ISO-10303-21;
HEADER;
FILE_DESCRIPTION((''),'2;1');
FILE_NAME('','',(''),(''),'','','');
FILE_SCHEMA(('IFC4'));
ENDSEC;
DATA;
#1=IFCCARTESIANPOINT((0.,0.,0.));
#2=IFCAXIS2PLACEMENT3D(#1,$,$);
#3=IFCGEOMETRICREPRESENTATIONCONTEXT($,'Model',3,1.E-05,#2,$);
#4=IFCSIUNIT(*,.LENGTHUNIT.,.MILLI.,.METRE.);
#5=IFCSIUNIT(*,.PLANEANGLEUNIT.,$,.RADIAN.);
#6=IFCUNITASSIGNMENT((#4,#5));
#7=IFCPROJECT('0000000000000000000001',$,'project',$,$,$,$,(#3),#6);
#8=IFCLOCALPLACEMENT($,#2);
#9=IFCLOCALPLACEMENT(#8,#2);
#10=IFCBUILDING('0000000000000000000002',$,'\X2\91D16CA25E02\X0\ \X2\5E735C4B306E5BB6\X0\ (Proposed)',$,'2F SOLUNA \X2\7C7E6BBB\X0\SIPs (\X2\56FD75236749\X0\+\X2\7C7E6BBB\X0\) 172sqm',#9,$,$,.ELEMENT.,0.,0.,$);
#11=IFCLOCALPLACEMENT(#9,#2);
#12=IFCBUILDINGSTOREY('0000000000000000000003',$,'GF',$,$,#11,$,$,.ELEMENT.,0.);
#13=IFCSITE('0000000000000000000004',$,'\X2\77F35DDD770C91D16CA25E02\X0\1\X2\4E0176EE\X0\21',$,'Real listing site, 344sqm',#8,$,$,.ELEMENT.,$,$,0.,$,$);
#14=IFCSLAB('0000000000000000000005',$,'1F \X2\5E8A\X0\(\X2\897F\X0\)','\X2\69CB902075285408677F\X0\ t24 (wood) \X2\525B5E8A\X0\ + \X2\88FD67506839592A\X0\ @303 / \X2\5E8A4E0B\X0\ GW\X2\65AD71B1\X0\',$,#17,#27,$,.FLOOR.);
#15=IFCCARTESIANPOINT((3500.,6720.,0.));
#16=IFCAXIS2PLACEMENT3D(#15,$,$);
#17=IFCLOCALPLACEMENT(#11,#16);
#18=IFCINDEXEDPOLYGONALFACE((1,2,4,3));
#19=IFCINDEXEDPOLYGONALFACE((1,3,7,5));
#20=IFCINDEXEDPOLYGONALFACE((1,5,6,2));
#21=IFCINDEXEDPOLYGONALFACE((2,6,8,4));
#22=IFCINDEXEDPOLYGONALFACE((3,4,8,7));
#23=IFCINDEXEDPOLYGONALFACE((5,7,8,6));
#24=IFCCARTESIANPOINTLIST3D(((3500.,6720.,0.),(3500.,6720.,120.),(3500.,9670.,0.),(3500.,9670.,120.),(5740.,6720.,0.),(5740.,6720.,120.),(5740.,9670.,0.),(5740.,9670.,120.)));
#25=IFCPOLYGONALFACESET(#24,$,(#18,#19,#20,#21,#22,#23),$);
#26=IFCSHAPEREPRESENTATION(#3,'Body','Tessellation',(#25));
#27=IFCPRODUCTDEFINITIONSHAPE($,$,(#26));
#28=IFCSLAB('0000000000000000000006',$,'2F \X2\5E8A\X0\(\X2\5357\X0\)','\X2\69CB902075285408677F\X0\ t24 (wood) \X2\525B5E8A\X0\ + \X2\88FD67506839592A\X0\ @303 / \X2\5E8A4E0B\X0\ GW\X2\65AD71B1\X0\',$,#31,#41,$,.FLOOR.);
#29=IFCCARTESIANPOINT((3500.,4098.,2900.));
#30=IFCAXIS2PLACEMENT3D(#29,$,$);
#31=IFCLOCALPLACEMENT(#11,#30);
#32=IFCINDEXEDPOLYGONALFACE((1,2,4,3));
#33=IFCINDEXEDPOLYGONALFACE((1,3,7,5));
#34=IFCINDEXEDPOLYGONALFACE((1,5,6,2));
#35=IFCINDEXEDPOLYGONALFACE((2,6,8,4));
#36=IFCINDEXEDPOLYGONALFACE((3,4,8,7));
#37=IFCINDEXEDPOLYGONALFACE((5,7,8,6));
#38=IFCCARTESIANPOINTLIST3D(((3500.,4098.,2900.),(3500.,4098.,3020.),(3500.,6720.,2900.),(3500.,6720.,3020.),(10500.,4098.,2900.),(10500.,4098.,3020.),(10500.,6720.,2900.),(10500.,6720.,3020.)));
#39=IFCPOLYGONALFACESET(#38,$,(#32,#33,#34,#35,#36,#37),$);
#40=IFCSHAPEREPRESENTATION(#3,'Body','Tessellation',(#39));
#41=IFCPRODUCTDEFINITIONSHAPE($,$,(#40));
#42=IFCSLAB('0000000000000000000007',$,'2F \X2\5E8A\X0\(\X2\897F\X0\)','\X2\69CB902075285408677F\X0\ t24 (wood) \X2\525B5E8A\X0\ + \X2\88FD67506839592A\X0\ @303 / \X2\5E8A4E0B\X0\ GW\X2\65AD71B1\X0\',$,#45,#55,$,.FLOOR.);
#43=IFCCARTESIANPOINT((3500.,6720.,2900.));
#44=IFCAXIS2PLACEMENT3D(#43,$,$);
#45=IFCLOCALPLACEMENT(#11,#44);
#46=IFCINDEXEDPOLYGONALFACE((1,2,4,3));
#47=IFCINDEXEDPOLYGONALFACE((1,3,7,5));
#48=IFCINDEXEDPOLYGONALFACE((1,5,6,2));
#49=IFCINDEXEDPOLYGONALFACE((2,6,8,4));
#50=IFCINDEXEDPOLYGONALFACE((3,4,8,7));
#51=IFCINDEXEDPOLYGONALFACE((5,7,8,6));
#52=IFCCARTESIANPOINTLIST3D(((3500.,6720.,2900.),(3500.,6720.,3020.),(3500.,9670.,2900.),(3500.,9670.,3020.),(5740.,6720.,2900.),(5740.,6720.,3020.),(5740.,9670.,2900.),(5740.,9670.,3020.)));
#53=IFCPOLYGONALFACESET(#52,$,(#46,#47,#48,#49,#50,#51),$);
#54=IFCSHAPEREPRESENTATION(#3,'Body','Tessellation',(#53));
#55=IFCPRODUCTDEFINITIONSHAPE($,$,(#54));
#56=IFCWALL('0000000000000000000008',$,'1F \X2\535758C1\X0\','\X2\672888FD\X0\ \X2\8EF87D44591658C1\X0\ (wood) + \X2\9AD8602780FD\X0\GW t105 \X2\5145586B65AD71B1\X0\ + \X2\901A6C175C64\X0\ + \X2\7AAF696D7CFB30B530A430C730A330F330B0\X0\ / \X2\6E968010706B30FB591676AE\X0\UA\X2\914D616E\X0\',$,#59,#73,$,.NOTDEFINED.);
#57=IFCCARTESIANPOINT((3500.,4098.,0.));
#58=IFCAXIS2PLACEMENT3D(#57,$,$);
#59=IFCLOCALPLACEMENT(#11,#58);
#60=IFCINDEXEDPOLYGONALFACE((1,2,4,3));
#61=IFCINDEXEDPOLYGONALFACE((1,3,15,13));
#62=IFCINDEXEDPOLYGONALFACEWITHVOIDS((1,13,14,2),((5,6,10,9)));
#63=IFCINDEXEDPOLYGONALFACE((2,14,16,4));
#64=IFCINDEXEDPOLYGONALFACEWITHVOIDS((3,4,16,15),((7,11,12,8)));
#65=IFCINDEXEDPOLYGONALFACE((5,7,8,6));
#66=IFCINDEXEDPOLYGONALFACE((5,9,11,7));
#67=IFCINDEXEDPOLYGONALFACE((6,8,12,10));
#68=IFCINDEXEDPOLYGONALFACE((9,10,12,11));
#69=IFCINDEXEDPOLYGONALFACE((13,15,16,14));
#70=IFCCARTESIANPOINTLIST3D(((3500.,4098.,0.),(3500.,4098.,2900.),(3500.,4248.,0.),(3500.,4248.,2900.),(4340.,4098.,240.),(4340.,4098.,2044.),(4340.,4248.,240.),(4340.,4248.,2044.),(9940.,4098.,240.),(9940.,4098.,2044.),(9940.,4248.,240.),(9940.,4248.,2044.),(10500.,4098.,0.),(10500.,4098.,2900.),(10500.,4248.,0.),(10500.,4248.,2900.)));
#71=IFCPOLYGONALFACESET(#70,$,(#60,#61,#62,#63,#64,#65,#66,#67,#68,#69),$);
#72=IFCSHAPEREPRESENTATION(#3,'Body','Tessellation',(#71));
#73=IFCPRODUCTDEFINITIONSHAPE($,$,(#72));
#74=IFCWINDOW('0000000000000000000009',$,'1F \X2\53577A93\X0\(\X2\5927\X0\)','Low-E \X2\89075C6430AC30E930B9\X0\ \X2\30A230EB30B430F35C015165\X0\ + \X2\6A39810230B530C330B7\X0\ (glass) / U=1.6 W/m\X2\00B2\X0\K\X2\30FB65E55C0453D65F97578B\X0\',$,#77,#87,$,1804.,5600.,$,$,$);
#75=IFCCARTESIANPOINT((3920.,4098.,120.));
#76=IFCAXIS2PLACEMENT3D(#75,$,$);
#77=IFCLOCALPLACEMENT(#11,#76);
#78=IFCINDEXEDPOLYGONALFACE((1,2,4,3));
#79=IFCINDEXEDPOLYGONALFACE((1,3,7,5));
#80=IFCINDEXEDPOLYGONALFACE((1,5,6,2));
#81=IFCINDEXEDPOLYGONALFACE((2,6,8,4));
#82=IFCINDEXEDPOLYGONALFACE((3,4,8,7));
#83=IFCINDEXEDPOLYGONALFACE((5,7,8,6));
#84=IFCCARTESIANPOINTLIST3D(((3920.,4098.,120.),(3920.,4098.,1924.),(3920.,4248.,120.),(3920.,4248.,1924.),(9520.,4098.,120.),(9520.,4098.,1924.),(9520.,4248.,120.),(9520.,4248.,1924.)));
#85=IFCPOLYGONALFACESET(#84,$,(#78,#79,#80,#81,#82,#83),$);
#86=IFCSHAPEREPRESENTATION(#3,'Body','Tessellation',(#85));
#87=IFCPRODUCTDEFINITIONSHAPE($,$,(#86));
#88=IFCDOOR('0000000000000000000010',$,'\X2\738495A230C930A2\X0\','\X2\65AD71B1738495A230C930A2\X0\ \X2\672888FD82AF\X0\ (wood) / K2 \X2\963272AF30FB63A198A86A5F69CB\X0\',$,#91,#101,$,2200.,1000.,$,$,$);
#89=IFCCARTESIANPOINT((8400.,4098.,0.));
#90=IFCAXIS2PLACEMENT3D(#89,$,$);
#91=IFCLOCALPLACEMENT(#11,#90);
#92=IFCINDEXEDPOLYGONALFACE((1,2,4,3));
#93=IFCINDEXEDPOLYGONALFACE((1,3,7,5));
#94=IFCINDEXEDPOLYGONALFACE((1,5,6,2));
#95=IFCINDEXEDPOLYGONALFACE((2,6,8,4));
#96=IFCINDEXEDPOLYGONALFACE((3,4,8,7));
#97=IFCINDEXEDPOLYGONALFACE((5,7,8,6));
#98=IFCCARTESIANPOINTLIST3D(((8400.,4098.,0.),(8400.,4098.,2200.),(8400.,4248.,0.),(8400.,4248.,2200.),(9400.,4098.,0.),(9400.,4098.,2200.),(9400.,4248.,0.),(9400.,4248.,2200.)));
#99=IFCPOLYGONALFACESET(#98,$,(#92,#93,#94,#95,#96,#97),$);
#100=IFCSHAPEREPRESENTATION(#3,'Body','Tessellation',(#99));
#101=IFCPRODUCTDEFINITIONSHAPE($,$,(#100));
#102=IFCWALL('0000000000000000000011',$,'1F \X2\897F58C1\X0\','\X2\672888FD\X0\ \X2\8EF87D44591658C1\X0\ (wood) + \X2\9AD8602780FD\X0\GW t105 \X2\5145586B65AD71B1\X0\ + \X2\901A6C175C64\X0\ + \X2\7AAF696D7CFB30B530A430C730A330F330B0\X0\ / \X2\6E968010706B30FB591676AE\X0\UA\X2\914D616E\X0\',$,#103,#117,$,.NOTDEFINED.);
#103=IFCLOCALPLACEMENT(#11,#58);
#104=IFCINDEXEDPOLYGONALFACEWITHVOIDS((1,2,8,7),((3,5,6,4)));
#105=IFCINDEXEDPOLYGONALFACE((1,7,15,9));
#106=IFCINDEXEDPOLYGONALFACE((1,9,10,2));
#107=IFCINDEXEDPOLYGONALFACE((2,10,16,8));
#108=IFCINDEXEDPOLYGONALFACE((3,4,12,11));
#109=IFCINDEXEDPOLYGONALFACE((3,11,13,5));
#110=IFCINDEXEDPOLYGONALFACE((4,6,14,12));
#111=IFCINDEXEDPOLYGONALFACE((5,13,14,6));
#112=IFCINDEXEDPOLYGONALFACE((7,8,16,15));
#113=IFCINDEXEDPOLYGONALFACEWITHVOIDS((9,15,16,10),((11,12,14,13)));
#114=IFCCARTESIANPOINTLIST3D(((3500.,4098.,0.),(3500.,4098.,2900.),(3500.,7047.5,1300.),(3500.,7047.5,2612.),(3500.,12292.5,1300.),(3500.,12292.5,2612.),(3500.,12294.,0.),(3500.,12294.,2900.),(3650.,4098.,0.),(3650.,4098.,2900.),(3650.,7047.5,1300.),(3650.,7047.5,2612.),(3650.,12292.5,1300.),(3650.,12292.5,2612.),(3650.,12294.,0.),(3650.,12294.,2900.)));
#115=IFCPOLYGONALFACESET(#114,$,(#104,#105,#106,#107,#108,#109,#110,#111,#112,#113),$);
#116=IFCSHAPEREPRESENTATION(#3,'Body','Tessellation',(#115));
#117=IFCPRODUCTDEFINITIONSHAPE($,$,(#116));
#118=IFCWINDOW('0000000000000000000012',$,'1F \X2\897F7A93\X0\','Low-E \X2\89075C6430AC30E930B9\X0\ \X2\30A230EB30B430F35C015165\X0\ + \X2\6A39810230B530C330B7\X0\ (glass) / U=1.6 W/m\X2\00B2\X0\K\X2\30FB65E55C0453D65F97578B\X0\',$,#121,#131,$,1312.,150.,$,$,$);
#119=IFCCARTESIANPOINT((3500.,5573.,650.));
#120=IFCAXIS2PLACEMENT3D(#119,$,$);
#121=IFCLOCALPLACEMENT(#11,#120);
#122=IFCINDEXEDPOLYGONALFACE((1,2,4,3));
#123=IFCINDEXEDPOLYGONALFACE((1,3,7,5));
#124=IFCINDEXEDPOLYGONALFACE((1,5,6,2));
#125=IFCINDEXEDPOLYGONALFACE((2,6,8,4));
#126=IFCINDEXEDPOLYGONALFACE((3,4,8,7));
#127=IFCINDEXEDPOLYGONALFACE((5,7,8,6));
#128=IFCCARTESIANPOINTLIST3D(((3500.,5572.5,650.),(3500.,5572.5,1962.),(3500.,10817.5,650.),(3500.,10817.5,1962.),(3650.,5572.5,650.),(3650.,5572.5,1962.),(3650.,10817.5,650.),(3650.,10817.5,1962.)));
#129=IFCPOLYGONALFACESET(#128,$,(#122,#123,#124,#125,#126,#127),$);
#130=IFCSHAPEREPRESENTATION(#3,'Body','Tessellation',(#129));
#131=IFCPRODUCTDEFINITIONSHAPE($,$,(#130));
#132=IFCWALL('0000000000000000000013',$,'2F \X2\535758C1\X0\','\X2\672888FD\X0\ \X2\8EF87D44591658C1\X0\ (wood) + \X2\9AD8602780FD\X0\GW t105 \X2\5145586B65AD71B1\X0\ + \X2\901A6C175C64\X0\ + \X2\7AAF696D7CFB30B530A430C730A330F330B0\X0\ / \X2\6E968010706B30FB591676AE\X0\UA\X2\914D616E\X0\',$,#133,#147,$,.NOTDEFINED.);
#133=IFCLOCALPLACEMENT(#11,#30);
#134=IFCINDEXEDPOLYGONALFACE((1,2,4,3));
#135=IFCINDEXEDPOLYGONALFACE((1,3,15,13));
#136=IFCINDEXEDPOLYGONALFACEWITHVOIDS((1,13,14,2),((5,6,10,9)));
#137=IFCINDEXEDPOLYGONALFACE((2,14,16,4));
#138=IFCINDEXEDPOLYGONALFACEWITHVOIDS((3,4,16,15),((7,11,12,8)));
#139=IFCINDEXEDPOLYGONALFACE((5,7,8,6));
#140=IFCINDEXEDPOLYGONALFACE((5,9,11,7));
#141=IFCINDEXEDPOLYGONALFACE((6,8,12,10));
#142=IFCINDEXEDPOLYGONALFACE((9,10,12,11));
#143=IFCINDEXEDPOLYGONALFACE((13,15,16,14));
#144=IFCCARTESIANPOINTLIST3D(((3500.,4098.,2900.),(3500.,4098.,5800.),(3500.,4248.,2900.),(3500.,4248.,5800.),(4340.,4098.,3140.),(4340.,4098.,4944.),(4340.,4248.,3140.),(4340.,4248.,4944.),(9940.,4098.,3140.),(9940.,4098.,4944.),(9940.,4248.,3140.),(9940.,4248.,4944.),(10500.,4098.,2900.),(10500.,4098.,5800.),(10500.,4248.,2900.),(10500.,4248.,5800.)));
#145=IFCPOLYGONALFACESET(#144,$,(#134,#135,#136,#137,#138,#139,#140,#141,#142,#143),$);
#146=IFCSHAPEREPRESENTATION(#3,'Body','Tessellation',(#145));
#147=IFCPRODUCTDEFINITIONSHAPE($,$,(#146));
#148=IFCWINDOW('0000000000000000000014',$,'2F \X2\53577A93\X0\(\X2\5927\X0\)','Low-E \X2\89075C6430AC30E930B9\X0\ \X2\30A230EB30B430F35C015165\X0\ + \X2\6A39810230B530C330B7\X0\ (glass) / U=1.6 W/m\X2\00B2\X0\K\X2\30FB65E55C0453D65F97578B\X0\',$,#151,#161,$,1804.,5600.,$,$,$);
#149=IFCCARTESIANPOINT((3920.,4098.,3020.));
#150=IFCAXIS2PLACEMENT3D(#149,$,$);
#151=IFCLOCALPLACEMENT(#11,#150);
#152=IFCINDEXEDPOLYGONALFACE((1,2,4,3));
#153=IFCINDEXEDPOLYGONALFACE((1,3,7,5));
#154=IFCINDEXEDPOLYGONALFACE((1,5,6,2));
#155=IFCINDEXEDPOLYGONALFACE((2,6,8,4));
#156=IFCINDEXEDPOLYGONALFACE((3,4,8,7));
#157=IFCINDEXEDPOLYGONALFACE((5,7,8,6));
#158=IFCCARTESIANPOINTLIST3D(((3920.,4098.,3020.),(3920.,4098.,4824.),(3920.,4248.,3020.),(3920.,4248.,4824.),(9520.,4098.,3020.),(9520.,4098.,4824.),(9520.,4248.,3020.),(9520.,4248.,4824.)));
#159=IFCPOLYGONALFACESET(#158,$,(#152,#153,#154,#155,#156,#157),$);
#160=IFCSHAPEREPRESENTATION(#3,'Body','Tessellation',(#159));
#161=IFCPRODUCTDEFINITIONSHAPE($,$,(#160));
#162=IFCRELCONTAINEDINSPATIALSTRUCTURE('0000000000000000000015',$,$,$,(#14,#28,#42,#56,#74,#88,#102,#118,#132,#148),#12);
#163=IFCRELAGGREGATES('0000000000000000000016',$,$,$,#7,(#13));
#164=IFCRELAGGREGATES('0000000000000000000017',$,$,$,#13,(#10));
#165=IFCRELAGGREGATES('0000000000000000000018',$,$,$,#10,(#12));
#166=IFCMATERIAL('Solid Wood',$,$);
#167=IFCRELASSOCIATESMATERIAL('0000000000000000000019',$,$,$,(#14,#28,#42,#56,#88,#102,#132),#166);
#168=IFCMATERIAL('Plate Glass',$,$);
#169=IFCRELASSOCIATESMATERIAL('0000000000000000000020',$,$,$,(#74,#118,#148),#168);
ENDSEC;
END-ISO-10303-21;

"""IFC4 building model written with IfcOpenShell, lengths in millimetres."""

from ifc_helpers import new_model, si_unit, frame, frame_2d, origin, place, context, project, spatial, rectangle, extrude, material, element, fill, save


model = new_model("IFC4")

# Units and contexts
model_context = context("Model", 3, precision=1e-05, world=origin())
ifc_project = project(units=[si_unit("LENGTHUNIT", "METRE", prefix="MILLI"), si_unit("PLANEANGLEUNIT", "RADIAN")], contexts=[model_context])

# Site, building, storey
site_placement = place(None, origin())
site = spatial("IfcSite", under=ifc_project, at=site_placement, Name="石川県金沢市1丁目21", ObjectType="Real listing site, 344sqm", CompositionType="ELEMENT", RefElevation=0.0)
building_placement = place(site_placement, origin())
building = spatial("IfcBuilding", under=site, at=building_placement, Name="金沢市 平屋の家 (Proposed)", ObjectType="2F SOLUNA 籾殻SIPs (国産杉+籾殻) 172sqm", CompositionType="ELEMENT", ElevationOfRefHeight=0.0, ElevationOfTerrain=0.0)
storey_placement = place(building_placement, origin())
storey = spatial("IfcBuildingStorey", under=building, at=storey_placement, Name="GF", CompositionType="ELEMENT", Elevation=0.0)

# Slabs
ifc_material_1 = material(Name="Solid Wood")
slab_1_placement = place(storey_placement, frame((3500.0, 6720.0, 0.0)))
element("IfcSlab", 1, at=slab_1_placement, inside=storey, material=ifc_material_1, Name="1F 床(西)", Description="構造用合板 t24 (wood) 剛床 + 製材根太 @303 / 床下 GW断熱", PredefinedType="FLOOR", context=model_context, shape_type="SweptSolid", body=[
    extrude(rectangle(XDim=2240.0, YDim=2950.0, at=frame_2d((1120.0, 1475.0))), frame((3500.0, 6720.0, 0.0)), (0.0, 0.0, 1.0), 120.0),
])
slab_2_placement = place(storey_placement, frame((3500.0, 4098.0, 2900.0)))
element("IfcSlab", 2, at=slab_2_placement, inside=storey, material=ifc_material_1, Name="2F 床(南)", Description="構造用合板 t24 (wood) 剛床 + 製材根太 @303 / 床下 GW断熱", PredefinedType="FLOOR", context=model_context, shape_type="SweptSolid", body=[
    extrude(rectangle(XDim=7000.0, YDim=2622.0, at=frame_2d((3500.0, 1311.0))), frame((3500.0, 4098.0, 2900.0)), (0.0, 0.0, 1.0), 120.0),
])
slab_3_placement = place(storey_placement, frame((3500.0, 6720.0, 2900.0)))
element("IfcSlab", 3, at=slab_3_placement, inside=storey, material=ifc_material_1, Name="2F 床(西)", Description="構造用合板 t24 (wood) 剛床 + 製材根太 @303 / 床下 GW断熱", PredefinedType="FLOOR", context=model_context, shape_type="SweptSolid", body=[
    extrude(rectangle(XDim=2240.0, YDim=2950.0, at=frame_2d((1120.0, 1475.0))), frame((3500.0, 6720.0, 2900.0)), (0.0, 0.0, 1.0), 120.0),
])

# Wall, openings, window, door
wall_1_placement = place(storey_placement, frame((3500.0, 4098.0, 0.0)))
wall_1 = element("IfcWall", 4, at=wall_1_placement, inside=storey, material=ifc_material_1, Name="1F 南壁", Description="木製 軸組外壁 (wood) + 高性能GW t105 充填断熱 + 通気層 + 窯業系サイディング / 準耐火・外皮UA配慮", PredefinedType="NOTDEFINED", context=model_context, shape_type="SweptSolid", body=[
    extrude(rectangle(XDim=7000.0, YDim=150.0, at=frame_2d((3500.0, 75.0))), frame((3500.0, 4098.0, 0.0)), (0.0, 0.0, 1.0), 2900.0),
])
opening_1_placement = place(storey_placement, frame((3920.0, 4098.0, 120.0)))
opening_1 = element("IfcOpeningElement", 5, at=opening_1_placement, cuts=wall_1, PredefinedType="NOTDEFINED", context=model_context, shape_type="SweptSolid", body=[
    extrude(rectangle(XDim=5600.0, YDim=150.0, at=frame_2d((2800.0, 75.0))), frame((3920.0, 4098.0, 120.0)), (0.0, 0.0, 1.0), 1804.0),
])
opening_2_placement = place(storey_placement, frame((8400.0, 4098.0, 0.0)))
opening_2 = element("IfcOpeningElement", 6, at=opening_2_placement, cuts=wall_1, PredefinedType="NOTDEFINED", context=model_context, shape_type="SweptSolid", body=[
    extrude(rectangle(XDim=1000.0, YDim=150.0, at=frame_2d((500.0, 75.0))), frame((8400.0, 4098.0, 0.0)), (0.0, 0.0, 1.0), 2200.0),
])
ifc_material_2 = material(Name="Plate Glass")
window_1_placement = place(storey_placement, frame((3920.0, 4098.0, 120.0)))
window_1 = element("IfcWindow", 7, at=window_1_placement, inside=storey, material=ifc_material_2, Name="1F 南窓(大)", Description="Low-E 複層ガラス アルゴン封入 + 樹脂サッシ (glass) / U=1.6 W/m²K・日射取得型", OverallHeight=1804.0, OverallWidth=5600.0, context=model_context, shape_type="SweptSolid", body=[
    extrude(rectangle(XDim=5600.0, YDim=150.0, at=frame_2d((2800.0, 75.0))), frame((3920.0, 4098.0, 120.0)), (0.0, 0.0, 1.0), 1804.0),
])
fill(opening_1, window_1)
door_placement = place(storey_placement, frame((8400.0, 4098.0, 0.0)))
door = element("IfcDoor", 8, at=door_placement, inside=storey, material=ifc_material_1, Name="玄関ドア", Description="断熱玄関ドア 木製芯 (wood) / K2 防犯・採風機構", OverallHeight=2200.0, OverallWidth=1000.0, context=model_context, shape_type="SweptSolid", body=[
    extrude(rectangle(XDim=1000.0, YDim=150.0, at=frame_2d((500.0, 75.0))), frame((8400.0, 4098.0, 0.0)), (0.0, 0.0, 1.0), 2200.0),
])
fill(opening_2, door)

# Walls, openings, windows
wall_2_placement = place(storey_placement, frame((3500.0, 4098.0, 0.0)))
wall_2 = element("IfcWall", 9, at=wall_2_placement, inside=storey, material=ifc_material_1, Name="1F 西壁", Description="木製 軸組外壁 (wood) + 高性能GW t105 充填断熱 + 通気層 + 窯業系サイディング / 準耐火・外皮UA配慮", PredefinedType="NOTDEFINED", context=model_context, shape_type="SweptSolid", body=[
    extrude(rectangle(XDim=150.0, YDim=8196.0, at=frame_2d((75.0, 4098.0))), frame((3500.0, 4098.0, 0.0)), (0.0, 0.0, 1.0), 2900.0),
])
opening_3_placement = place(storey_placement, frame((3500.0, 5573.0, 650.0)))
opening_3 = element("IfcOpeningElement", 10, at=opening_3_placement, cuts=wall_2, PredefinedType="NOTDEFINED", context=model_context, shape_type="SweptSolid", body=[
    extrude(rectangle(XDim=150.0, YDim=5245.0, at=frame_2d((75.0, 2622.0))), frame((3500.0, 5573.0, 650.0)), (0.0, 0.0, 1.0), 1312.0),
])
window_2_placement = place(storey_placement, frame((3500.0, 5573.0, 650.0)))
window_2 = element("IfcWindow", 11, at=window_2_placement, inside=storey, material=ifc_material_2, Name="1F 西窓", Description="Low-E 複層ガラス アルゴン封入 + 樹脂サッシ (glass) / U=1.6 W/m²K・日射取得型", OverallHeight=1312.0, OverallWidth=150.0, context=model_context, shape_type="SweptSolid", body=[
    extrude(rectangle(XDim=150.0, YDim=5245.0, at=frame_2d((75.0, 2622.0))), frame((3500.0, 5573.0, 650.0)), (0.0, 0.0, 1.0), 1312.0),
])
fill(opening_3, window_2)
wall_3_placement = place(storey_placement, frame((3500.0, 4098.0, 2900.0)))
wall_3 = element("IfcWall", 12, at=wall_3_placement, inside=storey, material=ifc_material_1, Name="2F 南壁", Description="木製 軸組外壁 (wood) + 高性能GW t105 充填断熱 + 通気層 + 窯業系サイディング / 準耐火・外皮UA配慮", PredefinedType="NOTDEFINED", context=model_context, shape_type="SweptSolid", body=[
    extrude(rectangle(XDim=7000.0, YDim=150.0, at=frame_2d((3500.0, 75.0))), frame((3500.0, 4098.0, 2900.0)), (0.0, 0.0, 1.0), 2900.0),
])
opening_4_placement = place(storey_placement, frame((3920.0, 4098.0, 3020.0)))
opening_4 = element("IfcOpeningElement", 13, at=opening_4_placement, cuts=wall_3, PredefinedType="NOTDEFINED", context=model_context, shape_type="SweptSolid", body=[
    extrude(rectangle(XDim=5600.0, YDim=150.0, at=frame_2d((2800.0, 75.0))), frame((3920.0, 4098.0, 3020.0)), (0.0, 0.0, 1.0), 1804.0),
])
window_3_placement = place(storey_placement, frame((3920.0, 4098.0, 3020.0)))
window_3 = element("IfcWindow", 14, at=window_3_placement, inside=storey, material=ifc_material_2, Name="2F 南窓(大)", Description="Low-E 複層ガラス アルゴン封入 + 樹脂サッシ (glass) / U=1.6 W/m²K・日射取得型", OverallHeight=1804.0, OverallWidth=5600.0, context=model_context, shape_type="SweptSolid", body=[
    extrude(rectangle(XDim=5600.0, YDim=150.0, at=frame_2d((2800.0, 75.0))), frame((3920.0, 4098.0, 3020.0)), (0.0, 0.0, 1.0), 1804.0),
])
fill(opening_4, window_3)

save(model, "model.ifc")
